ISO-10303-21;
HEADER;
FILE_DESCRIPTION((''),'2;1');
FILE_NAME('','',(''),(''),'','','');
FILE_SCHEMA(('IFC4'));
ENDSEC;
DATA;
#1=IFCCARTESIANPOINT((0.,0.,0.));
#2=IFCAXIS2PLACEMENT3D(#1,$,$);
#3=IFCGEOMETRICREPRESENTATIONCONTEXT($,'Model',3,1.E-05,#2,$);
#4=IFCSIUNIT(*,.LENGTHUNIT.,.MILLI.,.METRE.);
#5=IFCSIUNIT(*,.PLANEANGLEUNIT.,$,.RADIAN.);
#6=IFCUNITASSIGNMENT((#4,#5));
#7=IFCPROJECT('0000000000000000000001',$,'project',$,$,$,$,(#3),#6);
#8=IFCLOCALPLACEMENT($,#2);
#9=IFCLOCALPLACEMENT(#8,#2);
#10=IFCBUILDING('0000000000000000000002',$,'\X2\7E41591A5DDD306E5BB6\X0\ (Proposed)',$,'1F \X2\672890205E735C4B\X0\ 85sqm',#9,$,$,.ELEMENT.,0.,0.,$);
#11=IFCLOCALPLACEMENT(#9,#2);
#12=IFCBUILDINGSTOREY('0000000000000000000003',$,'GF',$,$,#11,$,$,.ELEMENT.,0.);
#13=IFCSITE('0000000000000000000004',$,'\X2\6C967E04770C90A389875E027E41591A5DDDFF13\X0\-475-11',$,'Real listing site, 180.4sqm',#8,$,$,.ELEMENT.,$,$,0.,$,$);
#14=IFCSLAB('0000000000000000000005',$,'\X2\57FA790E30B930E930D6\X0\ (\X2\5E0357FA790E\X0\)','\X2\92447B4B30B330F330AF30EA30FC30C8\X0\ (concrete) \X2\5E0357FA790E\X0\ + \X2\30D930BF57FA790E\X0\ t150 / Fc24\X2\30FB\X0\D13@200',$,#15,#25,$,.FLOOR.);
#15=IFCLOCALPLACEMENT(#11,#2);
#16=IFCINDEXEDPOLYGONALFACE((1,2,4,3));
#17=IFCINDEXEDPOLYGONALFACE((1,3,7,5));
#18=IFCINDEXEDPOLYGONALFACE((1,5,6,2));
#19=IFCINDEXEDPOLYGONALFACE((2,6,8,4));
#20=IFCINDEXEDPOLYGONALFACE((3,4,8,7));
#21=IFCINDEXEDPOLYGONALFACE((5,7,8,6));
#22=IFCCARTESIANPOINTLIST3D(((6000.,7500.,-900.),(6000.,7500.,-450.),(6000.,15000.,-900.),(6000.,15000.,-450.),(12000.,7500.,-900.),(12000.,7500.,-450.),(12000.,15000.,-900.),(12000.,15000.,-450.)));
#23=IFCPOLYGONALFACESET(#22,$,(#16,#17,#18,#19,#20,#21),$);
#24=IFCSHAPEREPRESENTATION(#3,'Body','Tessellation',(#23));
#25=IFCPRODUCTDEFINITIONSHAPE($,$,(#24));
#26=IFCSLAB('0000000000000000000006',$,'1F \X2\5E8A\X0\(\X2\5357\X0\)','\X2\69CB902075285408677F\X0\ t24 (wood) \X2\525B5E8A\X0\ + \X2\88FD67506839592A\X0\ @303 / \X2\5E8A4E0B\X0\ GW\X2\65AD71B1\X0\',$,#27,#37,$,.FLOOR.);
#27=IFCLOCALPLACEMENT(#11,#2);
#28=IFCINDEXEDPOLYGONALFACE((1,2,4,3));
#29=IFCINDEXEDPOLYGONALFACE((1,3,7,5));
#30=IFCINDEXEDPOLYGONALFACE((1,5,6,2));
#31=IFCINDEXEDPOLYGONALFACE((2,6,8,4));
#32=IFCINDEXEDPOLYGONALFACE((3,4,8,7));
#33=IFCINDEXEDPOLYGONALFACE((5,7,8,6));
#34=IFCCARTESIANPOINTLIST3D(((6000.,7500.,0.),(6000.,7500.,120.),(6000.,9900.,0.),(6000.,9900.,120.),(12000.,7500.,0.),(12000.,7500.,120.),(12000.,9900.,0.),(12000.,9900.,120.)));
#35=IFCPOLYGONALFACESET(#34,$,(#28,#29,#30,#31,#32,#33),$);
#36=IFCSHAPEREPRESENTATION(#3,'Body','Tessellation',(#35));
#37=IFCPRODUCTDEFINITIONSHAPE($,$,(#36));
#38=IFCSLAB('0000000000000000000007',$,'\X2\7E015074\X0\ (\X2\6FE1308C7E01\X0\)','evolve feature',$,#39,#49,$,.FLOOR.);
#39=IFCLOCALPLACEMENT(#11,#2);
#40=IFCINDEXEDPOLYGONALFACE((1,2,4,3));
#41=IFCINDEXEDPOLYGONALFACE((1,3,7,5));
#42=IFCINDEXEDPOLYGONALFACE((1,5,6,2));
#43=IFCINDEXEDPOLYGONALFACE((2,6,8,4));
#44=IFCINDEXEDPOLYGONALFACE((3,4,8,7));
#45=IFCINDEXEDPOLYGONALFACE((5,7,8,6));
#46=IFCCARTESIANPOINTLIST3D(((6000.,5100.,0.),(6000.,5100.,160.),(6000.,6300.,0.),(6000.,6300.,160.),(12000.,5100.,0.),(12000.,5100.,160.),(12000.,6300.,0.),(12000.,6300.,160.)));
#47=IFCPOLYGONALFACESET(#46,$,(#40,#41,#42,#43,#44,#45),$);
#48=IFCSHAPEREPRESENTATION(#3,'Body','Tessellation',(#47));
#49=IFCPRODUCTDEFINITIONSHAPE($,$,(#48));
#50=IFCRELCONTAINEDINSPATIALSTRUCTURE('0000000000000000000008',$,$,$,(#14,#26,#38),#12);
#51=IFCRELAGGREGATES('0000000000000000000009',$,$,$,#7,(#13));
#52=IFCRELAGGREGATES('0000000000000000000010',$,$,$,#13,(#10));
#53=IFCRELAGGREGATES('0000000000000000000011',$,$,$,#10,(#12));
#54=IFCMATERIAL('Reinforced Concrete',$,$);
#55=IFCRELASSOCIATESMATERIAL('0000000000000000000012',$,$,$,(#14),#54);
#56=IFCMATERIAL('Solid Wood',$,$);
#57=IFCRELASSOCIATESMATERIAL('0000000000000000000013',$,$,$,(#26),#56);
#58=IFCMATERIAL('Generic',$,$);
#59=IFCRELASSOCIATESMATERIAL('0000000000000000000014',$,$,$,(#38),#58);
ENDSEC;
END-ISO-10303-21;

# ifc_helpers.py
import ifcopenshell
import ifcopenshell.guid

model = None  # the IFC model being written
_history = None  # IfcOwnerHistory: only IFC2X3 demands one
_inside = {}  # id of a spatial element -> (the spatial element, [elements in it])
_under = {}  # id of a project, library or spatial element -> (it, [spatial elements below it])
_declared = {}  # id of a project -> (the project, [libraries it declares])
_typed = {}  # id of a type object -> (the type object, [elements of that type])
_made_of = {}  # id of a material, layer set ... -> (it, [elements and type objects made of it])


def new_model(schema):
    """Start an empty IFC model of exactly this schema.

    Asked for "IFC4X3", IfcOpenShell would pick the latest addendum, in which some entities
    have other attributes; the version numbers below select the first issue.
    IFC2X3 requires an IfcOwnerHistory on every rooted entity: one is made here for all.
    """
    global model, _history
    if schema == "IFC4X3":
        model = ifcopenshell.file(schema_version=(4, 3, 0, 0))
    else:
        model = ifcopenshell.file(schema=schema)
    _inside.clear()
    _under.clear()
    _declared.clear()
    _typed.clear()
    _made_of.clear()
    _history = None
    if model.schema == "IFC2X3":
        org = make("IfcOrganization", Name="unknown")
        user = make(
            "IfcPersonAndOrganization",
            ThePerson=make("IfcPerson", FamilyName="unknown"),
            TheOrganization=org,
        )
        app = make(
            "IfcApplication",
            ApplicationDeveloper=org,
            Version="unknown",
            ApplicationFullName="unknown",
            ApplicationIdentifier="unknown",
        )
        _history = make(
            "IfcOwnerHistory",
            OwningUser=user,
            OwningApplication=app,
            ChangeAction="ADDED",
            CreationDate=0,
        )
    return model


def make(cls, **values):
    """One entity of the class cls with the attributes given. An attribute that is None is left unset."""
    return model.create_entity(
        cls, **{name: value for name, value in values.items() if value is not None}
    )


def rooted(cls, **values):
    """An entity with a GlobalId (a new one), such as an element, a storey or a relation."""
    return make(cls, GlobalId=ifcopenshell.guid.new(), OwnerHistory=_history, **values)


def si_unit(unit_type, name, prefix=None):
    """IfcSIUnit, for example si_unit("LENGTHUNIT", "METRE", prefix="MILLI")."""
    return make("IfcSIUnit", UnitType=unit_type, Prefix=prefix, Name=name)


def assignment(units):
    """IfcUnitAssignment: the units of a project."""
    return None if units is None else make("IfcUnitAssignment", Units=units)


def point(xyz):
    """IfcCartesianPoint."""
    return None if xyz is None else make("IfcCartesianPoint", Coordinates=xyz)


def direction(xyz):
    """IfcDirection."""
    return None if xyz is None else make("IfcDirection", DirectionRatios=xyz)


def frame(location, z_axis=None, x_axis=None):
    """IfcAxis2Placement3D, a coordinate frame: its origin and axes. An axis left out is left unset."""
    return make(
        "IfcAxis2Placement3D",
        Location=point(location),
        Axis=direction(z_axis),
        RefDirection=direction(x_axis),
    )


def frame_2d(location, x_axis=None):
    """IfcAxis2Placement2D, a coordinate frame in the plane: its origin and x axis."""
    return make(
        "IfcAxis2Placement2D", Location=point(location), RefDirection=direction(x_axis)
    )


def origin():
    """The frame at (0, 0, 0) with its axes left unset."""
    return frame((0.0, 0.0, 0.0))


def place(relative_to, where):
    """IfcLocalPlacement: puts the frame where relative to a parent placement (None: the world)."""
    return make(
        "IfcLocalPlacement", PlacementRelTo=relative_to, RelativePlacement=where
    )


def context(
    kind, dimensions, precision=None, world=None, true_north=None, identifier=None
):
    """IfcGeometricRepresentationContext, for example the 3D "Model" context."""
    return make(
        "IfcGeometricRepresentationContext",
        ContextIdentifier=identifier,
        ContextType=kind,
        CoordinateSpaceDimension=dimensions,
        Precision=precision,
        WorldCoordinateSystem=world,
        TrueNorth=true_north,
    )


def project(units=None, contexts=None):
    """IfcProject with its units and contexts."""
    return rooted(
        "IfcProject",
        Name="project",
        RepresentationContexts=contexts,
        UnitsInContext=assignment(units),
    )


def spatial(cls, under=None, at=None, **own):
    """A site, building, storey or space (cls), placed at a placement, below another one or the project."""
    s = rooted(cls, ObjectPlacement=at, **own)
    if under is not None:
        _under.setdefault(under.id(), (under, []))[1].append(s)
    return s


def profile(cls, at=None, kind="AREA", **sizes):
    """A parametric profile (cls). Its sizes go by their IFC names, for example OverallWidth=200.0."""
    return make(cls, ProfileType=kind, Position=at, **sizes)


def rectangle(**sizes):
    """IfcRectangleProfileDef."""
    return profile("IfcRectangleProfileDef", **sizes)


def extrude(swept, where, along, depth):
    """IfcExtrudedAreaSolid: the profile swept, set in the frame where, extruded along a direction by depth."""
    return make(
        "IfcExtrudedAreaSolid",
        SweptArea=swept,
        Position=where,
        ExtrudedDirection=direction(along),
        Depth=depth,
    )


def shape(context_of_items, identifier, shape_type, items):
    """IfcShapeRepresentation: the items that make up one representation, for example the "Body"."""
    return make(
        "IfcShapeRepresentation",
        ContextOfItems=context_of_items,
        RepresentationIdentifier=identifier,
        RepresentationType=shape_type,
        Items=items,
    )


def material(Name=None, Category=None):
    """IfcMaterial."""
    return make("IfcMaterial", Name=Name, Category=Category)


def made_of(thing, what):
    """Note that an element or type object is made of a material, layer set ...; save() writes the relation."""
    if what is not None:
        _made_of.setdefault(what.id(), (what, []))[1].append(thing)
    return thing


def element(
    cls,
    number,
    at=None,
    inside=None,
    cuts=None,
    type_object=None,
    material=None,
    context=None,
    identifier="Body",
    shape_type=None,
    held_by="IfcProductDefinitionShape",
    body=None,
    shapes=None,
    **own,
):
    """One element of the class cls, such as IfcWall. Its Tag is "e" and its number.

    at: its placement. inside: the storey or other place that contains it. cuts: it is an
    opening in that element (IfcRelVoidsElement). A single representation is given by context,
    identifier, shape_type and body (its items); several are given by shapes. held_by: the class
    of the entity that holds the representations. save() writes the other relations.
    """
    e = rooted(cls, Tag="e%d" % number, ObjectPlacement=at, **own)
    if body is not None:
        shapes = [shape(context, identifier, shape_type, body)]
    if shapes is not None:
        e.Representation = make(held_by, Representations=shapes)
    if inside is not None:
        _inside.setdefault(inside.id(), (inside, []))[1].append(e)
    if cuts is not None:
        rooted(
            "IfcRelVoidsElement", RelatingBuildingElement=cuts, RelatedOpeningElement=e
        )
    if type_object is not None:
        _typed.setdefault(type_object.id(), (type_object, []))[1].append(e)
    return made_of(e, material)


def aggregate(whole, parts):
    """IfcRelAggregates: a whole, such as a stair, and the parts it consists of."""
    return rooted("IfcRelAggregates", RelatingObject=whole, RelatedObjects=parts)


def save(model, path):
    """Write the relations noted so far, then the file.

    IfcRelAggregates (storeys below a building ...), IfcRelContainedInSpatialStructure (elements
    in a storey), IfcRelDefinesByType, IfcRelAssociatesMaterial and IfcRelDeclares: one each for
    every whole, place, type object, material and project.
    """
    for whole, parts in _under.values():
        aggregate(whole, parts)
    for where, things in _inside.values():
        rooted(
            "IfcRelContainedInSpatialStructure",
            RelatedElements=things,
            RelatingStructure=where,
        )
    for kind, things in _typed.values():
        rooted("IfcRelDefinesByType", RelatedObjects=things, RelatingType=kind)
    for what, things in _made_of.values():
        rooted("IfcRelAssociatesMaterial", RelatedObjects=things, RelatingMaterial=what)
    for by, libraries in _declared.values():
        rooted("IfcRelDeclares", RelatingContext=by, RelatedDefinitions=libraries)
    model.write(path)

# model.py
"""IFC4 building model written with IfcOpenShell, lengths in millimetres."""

from ifc_helpers import new_model, si_unit, frame, frame_2d, origin, place, context, project, spatial, rectangle, extrude, material, element, save


model = new_model("IFC4")

# Units and contexts
model_context = context("Model", 3, precision=1e-05, world=origin())
ifc_project = project(units=[si_unit("LENGTHUNIT", "METRE", prefix="MILLI"), si_unit("PLANEANGLEUNIT", "RADIAN")], contexts=[model_context])

# Site, building, storey
site_placement = place(None, origin())
site = spatial("IfcSite", under=ifc_project, at=site_placement, Name="沖縄県那覇市繁多川３-475-11", ObjectType="Real listing site, 180.4sqm", CompositionType="ELEMENT", RefElevation=0.0)
building_placement = place(site_placement, origin())
building = spatial("IfcBuilding", under=site, at=building_placement, Name="繁多川の家 (Proposed)", ObjectType="1F 木造平屋 85sqm", CompositionType="ELEMENT", ElevationOfRefHeight=0.0, ElevationOfTerrain=0.0)
storey_placement = place(building_placement, origin())
storey = spatial("IfcBuildingStorey", under=building, at=storey_placement, Name="GF", CompositionType="ELEMENT", Elevation=0.0)

# Slabs
ifc_material_1 = material(Name="Reinforced Concrete")
slab_1_placement = place(storey_placement, frame((3000.0, 3750.0, -450.0)))
element("IfcSlab", 1, at=slab_1_placement, inside=storey, material=ifc_material_1, Name="基礎スラブ (布基礎)", Description="鉄筋コンクリート (concrete) 布基礎 + ベタ基礎 t150 / Fc24・D13@200", PredefinedType="FLOOR", context=model_context, shape_type="SweptSolid", body=[
    extrude(rectangle(XDim=6000.0, YDim=7500.0, at=frame_2d((3000.0, 3750.0))), frame((3000.0, 3750.0, -450.0)), (0.0, 0.0, 1.0), 450.0),
])
ifc_material_2 = material(Name="Solid Wood")
slab_2_placement = place(storey_placement, frame((3000.0, 3750.0, 0.0)))
element("IfcSlab", 2, at=slab_2_placement, inside=storey, material=ifc_material_2, Name="1F 床(南)", Description="構造用合板 t24 (wood) 剛床 + 製材根太 @303 / 床下 GW断熱", PredefinedType="FLOOR", context=model_context, shape_type="SweptSolid", body=[
    extrude(rectangle(XDim=6000.0, YDim=2400.0, at=frame_2d((3000.0, 1200.0))), frame((3000.0, 3750.0, 0.0)), (0.0, 0.0, 1.0), 120.0),
])
ifc_material_3 = material(Name="Generic")
slab_3_placement = place(storey_placement, frame((3000.0, 2550.0, 0.0)))
element("IfcSlab", 3, at=slab_3_placement, inside=storey, material=ifc_material_3, Name="縁側 (濡れ縁)", Description="evolve feature", PredefinedType="FLOOR", context=model_context, shape_type="SweptSolid", body=[
    extrude(rectangle(XDim=6000.0, YDim=1200.0, at=frame_2d((3000.0, 600.0))), frame((3000.0, 2550.0, 0.0)), (0.0, 0.0, 1.0), 160.0),
])

save(model, "model.ifc")
